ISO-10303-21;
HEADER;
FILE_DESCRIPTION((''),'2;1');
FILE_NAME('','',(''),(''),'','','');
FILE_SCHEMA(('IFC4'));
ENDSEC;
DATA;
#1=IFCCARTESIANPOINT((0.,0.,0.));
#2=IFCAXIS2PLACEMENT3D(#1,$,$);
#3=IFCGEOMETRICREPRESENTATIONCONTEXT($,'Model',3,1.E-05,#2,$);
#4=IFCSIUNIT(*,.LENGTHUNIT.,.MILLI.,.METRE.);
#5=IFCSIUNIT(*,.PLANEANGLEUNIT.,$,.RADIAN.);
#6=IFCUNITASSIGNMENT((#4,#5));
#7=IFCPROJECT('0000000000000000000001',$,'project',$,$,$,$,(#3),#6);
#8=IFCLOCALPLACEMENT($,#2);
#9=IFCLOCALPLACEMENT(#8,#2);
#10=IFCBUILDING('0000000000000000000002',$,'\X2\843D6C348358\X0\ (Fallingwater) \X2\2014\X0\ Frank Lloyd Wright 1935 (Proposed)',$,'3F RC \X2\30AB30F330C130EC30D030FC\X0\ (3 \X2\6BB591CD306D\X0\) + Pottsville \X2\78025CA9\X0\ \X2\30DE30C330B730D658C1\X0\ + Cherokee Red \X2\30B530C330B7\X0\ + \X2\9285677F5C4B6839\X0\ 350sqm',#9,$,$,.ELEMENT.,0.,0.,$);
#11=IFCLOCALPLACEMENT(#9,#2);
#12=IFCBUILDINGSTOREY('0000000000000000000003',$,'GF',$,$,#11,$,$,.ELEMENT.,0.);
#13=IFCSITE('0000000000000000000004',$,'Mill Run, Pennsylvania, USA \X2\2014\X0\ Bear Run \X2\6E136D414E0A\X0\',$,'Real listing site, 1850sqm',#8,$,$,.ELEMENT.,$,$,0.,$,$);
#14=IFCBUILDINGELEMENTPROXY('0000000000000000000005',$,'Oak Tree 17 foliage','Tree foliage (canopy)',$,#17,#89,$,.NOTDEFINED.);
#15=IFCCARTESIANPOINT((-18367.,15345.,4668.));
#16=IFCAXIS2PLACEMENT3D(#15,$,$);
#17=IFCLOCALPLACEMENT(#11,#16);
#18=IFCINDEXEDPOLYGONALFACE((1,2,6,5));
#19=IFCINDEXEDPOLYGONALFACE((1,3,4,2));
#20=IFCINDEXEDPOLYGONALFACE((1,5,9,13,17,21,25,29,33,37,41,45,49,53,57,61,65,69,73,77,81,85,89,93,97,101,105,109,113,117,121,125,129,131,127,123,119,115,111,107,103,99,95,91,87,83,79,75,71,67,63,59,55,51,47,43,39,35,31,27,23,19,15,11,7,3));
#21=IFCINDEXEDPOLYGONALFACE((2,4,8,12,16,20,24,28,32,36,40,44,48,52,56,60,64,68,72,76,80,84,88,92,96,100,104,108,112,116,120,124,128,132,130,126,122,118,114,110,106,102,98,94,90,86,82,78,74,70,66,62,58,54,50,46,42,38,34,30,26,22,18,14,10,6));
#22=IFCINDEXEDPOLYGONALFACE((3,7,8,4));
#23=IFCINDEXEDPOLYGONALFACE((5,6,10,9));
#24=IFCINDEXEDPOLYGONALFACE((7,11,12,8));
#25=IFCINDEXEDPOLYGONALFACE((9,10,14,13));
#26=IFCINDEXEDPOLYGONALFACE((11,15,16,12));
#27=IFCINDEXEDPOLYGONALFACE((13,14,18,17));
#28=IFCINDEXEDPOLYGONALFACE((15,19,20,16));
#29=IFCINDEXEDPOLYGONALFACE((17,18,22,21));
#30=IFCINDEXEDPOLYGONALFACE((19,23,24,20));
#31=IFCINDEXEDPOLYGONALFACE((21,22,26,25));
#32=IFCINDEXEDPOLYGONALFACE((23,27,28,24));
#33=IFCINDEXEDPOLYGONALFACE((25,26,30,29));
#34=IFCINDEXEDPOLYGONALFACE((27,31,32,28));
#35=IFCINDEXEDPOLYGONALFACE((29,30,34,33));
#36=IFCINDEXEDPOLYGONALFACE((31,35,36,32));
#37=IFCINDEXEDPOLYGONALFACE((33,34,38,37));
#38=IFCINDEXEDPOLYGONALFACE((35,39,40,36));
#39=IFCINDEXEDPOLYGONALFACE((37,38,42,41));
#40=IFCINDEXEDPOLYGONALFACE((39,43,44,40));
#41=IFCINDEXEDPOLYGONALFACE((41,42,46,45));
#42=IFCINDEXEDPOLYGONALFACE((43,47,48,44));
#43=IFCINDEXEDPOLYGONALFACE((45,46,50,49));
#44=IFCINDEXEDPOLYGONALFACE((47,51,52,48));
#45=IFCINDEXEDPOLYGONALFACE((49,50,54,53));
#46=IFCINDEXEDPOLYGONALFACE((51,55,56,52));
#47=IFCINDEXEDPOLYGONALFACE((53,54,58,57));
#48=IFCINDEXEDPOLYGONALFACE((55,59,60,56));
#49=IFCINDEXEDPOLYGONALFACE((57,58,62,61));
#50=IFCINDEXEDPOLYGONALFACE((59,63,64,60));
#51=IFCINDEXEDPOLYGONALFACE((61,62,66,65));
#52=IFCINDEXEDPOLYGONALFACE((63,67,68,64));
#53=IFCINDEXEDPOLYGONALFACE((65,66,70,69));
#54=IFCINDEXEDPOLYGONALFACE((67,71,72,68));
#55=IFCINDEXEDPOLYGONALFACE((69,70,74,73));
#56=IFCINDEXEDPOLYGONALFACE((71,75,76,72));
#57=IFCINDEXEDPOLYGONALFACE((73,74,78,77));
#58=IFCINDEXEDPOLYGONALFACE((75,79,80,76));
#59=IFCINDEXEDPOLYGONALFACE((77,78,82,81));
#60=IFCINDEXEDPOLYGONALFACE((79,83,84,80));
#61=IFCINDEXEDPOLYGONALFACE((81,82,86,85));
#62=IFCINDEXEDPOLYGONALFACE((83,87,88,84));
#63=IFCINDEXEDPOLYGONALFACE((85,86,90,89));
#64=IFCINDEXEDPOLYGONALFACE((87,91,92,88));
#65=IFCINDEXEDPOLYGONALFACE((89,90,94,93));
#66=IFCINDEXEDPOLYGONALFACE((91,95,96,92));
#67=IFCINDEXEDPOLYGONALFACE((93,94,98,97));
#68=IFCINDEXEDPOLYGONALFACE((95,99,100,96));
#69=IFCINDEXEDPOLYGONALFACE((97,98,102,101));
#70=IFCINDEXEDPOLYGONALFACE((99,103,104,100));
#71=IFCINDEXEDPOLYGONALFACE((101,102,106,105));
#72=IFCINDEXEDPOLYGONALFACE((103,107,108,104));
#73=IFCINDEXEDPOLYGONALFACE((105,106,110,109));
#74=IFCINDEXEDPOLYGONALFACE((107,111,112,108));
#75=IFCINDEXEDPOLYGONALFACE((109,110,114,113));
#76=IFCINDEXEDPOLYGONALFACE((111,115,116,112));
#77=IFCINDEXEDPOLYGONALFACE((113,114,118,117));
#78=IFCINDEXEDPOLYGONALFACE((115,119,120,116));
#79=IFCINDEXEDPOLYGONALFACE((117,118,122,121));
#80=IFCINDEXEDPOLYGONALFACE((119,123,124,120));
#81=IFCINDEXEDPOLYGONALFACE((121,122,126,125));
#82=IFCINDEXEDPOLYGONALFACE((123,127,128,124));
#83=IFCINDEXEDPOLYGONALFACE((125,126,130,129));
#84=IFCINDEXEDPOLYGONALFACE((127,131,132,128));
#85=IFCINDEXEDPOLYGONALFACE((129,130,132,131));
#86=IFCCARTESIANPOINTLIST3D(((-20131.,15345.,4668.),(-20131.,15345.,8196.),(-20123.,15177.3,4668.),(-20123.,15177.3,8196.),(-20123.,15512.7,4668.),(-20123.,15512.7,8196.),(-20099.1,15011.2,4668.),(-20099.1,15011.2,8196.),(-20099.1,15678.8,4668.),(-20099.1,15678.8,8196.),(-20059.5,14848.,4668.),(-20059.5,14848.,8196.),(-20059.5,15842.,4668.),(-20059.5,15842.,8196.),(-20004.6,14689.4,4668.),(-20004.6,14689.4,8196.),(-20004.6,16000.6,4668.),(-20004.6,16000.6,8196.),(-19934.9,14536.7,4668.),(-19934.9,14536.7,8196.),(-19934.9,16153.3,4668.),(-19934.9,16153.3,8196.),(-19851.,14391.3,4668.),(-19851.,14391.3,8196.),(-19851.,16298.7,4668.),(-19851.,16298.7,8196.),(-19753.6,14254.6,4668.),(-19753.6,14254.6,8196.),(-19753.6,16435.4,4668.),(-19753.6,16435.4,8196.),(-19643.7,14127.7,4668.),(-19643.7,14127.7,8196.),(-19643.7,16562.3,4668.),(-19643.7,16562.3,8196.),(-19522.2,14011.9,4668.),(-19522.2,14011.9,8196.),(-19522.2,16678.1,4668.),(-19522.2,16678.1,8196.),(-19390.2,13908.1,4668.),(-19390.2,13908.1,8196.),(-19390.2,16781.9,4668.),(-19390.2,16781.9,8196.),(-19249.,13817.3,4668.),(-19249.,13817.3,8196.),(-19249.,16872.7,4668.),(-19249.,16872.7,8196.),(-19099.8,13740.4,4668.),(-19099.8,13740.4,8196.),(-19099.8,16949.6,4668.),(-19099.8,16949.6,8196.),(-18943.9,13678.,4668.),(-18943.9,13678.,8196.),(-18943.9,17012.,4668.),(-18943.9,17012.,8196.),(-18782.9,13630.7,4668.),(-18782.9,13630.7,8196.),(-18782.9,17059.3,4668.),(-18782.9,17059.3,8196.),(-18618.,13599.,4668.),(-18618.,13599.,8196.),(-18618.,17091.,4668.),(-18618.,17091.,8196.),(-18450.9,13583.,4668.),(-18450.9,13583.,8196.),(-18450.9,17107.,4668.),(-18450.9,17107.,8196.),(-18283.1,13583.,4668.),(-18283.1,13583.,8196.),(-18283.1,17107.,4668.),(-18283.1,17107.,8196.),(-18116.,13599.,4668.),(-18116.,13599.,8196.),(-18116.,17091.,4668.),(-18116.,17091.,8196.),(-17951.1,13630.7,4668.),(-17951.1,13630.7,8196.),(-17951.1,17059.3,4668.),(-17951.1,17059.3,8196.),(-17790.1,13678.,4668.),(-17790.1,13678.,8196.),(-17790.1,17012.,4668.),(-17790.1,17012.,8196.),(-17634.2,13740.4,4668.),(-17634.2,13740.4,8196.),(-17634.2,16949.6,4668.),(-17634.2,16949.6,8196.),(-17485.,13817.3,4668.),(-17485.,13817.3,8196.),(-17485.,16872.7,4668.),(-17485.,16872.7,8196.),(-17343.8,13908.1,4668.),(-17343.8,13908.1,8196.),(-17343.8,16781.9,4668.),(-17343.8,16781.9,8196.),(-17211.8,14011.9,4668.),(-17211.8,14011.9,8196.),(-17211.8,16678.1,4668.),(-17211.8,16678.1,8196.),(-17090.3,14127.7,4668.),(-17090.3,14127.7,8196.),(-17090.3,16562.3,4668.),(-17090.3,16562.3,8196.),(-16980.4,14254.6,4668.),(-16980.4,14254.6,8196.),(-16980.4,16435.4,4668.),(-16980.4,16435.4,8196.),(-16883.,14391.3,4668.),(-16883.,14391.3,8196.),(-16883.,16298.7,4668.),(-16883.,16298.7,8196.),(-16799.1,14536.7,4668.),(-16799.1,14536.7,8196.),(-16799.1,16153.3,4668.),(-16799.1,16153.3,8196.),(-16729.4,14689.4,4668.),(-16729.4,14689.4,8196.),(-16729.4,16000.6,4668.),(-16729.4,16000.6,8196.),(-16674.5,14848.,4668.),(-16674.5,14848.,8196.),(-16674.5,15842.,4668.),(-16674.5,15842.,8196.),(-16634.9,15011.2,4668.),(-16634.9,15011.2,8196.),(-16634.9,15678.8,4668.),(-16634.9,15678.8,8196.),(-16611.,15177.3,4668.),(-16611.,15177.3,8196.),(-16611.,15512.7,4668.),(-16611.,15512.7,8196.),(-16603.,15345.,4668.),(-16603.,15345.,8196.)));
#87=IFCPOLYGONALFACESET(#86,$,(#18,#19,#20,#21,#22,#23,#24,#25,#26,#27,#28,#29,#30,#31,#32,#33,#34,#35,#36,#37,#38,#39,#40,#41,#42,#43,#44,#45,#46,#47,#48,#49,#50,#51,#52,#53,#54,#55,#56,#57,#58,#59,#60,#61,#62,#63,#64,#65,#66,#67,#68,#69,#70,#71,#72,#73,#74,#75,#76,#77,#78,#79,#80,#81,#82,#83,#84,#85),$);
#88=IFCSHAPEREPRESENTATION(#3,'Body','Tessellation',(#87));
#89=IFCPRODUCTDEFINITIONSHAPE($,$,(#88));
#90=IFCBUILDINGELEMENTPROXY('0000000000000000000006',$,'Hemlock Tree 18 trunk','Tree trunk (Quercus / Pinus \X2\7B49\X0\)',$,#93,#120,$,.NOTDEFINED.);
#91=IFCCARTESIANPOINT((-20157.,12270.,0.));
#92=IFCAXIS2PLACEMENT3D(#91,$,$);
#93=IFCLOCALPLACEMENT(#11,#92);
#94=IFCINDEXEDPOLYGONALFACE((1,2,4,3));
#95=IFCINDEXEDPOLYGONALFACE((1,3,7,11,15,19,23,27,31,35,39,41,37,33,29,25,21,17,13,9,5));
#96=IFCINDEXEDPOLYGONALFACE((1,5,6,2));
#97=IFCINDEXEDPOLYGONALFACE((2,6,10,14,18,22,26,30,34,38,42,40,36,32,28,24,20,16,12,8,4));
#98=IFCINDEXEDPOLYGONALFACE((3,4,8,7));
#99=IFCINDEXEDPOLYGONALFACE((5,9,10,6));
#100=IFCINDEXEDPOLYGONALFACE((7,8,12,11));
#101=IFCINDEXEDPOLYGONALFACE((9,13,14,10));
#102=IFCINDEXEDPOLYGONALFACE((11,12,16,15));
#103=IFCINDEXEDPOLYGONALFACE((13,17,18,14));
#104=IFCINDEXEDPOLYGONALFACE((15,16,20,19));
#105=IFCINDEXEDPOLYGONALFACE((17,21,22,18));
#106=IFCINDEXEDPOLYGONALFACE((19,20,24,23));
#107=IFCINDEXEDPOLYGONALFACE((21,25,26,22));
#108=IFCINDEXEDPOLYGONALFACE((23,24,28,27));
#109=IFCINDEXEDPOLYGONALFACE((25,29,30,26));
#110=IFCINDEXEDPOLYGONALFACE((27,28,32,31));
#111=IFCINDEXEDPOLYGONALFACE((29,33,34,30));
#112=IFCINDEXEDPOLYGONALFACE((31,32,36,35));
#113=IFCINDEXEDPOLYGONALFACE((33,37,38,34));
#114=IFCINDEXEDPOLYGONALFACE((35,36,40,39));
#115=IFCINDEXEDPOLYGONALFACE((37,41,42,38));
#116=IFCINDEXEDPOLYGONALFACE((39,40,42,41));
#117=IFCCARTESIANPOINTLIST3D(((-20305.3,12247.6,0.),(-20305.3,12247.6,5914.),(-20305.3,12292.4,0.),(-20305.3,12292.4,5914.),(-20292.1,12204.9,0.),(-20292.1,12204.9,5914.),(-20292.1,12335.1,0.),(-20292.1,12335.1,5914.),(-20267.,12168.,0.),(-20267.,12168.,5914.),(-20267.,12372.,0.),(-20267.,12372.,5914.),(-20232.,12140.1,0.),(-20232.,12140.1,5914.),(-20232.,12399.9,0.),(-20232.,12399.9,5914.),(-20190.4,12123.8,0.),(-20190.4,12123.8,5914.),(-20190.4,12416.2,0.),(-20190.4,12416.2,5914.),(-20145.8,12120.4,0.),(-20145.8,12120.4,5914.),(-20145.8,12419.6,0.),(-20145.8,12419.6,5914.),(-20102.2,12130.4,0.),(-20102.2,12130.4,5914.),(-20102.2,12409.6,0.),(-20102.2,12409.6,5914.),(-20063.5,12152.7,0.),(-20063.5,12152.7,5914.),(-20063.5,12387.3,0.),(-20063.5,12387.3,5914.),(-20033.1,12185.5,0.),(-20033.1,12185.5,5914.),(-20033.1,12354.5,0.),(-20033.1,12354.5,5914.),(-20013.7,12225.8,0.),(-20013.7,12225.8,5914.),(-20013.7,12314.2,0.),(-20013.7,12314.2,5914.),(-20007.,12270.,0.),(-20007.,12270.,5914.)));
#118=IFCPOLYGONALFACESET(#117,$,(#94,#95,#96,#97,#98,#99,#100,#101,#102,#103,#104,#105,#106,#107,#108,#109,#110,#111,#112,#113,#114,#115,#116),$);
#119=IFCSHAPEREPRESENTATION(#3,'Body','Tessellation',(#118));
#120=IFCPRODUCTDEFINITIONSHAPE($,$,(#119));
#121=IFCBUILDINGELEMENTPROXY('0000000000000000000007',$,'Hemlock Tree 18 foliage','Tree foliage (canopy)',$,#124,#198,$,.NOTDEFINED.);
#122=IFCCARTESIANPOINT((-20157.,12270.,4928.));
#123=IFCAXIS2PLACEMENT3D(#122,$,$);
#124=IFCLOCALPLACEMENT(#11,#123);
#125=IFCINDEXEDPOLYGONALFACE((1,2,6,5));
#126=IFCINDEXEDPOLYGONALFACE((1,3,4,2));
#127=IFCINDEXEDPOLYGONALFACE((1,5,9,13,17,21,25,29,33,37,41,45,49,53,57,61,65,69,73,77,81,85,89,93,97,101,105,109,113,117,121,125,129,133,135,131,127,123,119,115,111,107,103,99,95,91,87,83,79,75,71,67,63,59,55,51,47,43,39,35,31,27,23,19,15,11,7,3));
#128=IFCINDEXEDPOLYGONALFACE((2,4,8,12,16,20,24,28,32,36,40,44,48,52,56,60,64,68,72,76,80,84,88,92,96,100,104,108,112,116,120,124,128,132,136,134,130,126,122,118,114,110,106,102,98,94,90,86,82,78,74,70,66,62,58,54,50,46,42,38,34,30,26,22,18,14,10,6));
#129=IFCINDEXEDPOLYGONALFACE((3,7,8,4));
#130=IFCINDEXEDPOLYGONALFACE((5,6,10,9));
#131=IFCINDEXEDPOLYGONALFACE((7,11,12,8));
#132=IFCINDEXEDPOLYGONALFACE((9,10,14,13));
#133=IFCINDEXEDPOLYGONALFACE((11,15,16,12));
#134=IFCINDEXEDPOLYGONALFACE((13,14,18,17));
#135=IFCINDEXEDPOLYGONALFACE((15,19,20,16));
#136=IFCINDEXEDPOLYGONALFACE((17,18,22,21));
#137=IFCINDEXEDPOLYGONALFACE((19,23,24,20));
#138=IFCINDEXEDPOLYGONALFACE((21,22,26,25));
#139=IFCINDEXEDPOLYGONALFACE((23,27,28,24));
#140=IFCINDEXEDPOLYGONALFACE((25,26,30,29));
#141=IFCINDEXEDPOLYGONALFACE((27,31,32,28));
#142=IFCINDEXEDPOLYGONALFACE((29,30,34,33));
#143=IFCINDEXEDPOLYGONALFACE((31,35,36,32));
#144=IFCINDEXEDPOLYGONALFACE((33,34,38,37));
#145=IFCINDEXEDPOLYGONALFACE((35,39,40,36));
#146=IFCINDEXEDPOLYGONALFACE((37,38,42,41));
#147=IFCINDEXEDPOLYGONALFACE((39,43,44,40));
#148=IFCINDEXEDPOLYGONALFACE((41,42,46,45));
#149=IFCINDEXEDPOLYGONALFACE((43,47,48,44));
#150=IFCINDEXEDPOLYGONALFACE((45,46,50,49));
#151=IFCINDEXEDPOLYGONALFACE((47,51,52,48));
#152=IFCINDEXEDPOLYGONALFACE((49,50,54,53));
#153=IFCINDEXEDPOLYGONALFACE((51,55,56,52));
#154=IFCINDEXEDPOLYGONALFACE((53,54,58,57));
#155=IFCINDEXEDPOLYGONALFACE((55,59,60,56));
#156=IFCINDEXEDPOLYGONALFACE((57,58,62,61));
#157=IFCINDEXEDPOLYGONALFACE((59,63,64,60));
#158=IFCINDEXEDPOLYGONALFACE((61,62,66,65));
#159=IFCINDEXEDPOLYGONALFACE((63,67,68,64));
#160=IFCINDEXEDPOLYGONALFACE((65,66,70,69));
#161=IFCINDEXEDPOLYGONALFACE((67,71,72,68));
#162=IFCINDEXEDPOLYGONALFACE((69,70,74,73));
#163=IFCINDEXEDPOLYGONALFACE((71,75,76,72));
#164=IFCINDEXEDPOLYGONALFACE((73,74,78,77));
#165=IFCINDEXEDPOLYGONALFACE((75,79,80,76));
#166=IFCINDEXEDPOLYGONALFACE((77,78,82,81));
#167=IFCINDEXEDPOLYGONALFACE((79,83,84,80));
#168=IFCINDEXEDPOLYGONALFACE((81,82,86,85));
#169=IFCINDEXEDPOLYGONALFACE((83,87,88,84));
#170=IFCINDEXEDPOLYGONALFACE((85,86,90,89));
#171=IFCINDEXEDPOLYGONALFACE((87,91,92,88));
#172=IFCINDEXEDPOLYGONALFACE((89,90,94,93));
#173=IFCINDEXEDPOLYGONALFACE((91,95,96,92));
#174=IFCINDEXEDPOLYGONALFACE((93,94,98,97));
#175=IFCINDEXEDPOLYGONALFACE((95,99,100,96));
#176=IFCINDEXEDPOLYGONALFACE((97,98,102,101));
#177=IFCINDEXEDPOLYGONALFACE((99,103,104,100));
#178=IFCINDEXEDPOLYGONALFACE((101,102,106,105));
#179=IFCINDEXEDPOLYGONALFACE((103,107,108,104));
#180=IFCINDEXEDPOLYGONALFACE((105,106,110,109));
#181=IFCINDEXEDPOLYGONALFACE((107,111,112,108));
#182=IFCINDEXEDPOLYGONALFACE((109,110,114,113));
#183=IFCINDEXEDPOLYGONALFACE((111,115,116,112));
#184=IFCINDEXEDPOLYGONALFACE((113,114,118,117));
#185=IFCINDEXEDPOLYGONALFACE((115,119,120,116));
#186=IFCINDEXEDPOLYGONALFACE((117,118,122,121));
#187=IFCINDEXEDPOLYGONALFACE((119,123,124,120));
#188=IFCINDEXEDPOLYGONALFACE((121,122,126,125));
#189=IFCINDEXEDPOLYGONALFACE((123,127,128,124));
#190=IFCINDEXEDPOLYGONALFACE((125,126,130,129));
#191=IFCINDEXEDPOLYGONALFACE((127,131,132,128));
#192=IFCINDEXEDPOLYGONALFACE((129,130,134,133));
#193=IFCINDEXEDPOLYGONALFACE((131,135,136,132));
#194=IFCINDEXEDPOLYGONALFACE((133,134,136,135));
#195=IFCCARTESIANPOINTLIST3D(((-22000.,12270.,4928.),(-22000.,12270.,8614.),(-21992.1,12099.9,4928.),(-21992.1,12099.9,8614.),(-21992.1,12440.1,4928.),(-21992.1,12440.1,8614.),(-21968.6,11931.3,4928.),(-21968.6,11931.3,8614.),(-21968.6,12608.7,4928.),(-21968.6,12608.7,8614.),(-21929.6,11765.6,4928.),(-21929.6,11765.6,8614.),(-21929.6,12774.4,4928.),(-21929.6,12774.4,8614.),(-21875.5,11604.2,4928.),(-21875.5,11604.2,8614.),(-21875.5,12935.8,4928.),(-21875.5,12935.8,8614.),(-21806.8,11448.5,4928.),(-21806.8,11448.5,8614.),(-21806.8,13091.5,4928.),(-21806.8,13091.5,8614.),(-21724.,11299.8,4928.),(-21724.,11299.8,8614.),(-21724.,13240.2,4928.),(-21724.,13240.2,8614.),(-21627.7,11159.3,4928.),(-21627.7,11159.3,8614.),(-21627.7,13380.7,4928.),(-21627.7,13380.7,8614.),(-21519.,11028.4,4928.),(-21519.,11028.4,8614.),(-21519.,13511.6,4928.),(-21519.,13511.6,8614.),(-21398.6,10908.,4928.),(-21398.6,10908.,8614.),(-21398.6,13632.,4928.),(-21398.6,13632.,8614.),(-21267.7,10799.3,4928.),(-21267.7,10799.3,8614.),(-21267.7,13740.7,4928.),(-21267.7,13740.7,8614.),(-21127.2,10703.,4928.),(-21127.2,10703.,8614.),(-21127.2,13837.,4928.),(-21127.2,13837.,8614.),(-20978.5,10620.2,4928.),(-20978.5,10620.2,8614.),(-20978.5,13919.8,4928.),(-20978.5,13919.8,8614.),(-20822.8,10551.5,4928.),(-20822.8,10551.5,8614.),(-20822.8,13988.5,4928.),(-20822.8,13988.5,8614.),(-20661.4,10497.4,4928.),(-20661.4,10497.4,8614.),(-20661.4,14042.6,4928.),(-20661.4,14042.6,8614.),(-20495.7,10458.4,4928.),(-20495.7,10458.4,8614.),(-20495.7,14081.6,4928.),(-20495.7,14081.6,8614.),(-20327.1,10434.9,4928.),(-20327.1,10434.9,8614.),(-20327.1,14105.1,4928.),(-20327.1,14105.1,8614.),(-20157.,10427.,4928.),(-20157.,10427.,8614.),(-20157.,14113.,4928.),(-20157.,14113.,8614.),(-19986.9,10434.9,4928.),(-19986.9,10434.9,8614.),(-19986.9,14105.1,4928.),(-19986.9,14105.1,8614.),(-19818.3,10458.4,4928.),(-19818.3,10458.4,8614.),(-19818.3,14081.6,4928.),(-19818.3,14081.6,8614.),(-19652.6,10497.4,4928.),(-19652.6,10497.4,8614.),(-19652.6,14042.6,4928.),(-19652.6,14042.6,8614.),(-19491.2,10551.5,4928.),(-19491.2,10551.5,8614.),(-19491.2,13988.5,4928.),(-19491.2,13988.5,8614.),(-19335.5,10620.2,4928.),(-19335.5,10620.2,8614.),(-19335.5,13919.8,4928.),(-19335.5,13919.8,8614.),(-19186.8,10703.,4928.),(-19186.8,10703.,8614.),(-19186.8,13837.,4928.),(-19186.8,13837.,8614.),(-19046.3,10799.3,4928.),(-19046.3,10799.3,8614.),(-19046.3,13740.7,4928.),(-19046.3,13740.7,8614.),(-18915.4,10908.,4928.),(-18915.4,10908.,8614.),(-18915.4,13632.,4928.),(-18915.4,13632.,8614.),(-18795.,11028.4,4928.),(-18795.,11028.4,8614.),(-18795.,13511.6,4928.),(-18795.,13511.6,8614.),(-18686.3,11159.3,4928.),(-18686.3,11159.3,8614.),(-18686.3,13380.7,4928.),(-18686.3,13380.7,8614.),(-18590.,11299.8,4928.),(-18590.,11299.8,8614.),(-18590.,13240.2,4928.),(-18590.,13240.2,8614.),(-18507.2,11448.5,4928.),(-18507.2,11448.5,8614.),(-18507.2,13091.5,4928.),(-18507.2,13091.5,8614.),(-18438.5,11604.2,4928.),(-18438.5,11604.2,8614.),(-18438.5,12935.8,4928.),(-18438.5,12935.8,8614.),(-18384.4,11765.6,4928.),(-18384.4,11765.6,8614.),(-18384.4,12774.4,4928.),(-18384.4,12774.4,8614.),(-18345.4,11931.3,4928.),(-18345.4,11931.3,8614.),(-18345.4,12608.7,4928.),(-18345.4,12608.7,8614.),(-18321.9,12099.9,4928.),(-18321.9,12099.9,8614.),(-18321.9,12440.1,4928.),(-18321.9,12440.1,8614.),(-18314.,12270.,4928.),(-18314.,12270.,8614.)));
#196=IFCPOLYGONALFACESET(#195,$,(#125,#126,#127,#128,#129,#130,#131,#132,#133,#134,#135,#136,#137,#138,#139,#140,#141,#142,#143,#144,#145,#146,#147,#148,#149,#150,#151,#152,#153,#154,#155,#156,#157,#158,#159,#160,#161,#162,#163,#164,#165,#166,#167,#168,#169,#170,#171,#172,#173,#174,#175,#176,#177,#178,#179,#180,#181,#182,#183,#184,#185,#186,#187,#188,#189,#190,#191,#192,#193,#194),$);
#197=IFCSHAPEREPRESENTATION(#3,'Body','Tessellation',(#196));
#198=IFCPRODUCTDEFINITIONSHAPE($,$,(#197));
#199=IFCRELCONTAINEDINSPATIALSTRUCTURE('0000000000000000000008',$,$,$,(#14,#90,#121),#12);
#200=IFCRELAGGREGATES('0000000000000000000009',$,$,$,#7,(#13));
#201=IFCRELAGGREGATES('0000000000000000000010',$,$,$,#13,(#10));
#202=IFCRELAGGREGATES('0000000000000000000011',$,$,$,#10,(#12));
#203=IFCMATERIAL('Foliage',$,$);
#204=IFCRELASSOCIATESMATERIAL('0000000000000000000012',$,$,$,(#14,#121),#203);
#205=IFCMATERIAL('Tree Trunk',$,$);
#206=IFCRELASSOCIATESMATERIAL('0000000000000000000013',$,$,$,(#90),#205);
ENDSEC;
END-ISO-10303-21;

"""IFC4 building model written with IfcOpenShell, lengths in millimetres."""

from ifc_helpers import new_model, si_unit, frame, origin, origin_2d, place, context, project, spatial, circle, extrude, material, element, save


model = new_model("IFC4")

# Units and contexts
model_context = context("Model", 3, precision=1e-05, world=origin())
ifc_project = project(units=[si_unit("LENGTHUNIT", "METRE", prefix="MILLI"), si_unit("PLANEANGLEUNIT", "RADIAN")], contexts=[model_context])

# Site, building, storey
site_placement = place(None, origin())
site = spatial("IfcSite", under=ifc_project, at=site_placement, Name="Mill Run, Pennsylvania, USA — Bear Run 渓流上", ObjectType="Real listing site, 1850sqm", CompositionType="ELEMENT", RefElevation=0.0)
building_placement = place(site_placement, origin())
building = spatial("IfcBuilding", under=site, at=building_placement, Name="落水荘 (Fallingwater) — Frank Lloyd Wright 1935 (Proposed)", ObjectType="3F RC カンチレバー (3 段重ね) + Pottsville 砂岩 マッシブ壁 + Cherokee Red サッシ + 銅板屋根 350sqm", CompositionType="ELEMENT", ElevationOfRefHeight=0.0, ElevationOfTerrain=0.0)
storey_placement = place(building_placement, origin())
storey = spatial("IfcBuildingStorey", under=building, at=storey_placement, Name="GF", CompositionType="ELEMENT", Elevation=0.0)

# Building element proxies
ifc_material_1 = material(Name="Tree Trunk")
ifc_material_2 = material(Name="Foliage")
proxy_1_placement = place(storey_placement, frame((-18367.0, 15345.0, 4668.0)))
element("IfcBuildingElementProxy", 1, at=proxy_1_placement, inside=storey, material=ifc_material_2, Name="Oak Tree 17 foliage", Description="Tree foliage (canopy)", PredefinedType="NOTDEFINED", context=model_context, shape_type="SweptSolid", body=[
    extrude(circle(Radius=1764.0, at=origin_2d()), frame((-18367.0, 15345.0, 4668.0)), (0.0, 0.0, 1.0), 3528.0),
])
proxy_2_placement = place(storey_placement, frame((-20157.0, 12270.0, 0.0)))
element("IfcBuildingElementProxy", 2, at=proxy_2_placement, inside=storey, material=ifc_material_1, Name="Hemlock Tree 18 trunk", Description="Tree trunk (Quercus / Pinus 等)", PredefinedType="NOTDEFINED", context=model_context, shape_type="SweptSolid", body=[
    extrude(circle(Radius=150.0, at=origin_2d()), frame((-20157.0, 12270.0, 0.0)), (0.0, 0.0, 1.0), 5914.0),
])
proxy_3_placement = place(storey_placement, frame((-20157.0, 12270.0, 4928.0)))
element("IfcBuildingElementProxy", 3, at=proxy_3_placement, inside=storey, material=ifc_material_2, Name="Hemlock Tree 18 foliage", Description="Tree foliage (canopy)", PredefinedType="NOTDEFINED", context=model_context, shape_type="SweptSolid", body=[
    extrude(circle(Radius=1843.0, at=origin_2d()), frame((-20157.0, 12270.0, 4928.0)), (0.0, 0.0, 1.0), 3686.0),
])

save(model, "model.ifc")
